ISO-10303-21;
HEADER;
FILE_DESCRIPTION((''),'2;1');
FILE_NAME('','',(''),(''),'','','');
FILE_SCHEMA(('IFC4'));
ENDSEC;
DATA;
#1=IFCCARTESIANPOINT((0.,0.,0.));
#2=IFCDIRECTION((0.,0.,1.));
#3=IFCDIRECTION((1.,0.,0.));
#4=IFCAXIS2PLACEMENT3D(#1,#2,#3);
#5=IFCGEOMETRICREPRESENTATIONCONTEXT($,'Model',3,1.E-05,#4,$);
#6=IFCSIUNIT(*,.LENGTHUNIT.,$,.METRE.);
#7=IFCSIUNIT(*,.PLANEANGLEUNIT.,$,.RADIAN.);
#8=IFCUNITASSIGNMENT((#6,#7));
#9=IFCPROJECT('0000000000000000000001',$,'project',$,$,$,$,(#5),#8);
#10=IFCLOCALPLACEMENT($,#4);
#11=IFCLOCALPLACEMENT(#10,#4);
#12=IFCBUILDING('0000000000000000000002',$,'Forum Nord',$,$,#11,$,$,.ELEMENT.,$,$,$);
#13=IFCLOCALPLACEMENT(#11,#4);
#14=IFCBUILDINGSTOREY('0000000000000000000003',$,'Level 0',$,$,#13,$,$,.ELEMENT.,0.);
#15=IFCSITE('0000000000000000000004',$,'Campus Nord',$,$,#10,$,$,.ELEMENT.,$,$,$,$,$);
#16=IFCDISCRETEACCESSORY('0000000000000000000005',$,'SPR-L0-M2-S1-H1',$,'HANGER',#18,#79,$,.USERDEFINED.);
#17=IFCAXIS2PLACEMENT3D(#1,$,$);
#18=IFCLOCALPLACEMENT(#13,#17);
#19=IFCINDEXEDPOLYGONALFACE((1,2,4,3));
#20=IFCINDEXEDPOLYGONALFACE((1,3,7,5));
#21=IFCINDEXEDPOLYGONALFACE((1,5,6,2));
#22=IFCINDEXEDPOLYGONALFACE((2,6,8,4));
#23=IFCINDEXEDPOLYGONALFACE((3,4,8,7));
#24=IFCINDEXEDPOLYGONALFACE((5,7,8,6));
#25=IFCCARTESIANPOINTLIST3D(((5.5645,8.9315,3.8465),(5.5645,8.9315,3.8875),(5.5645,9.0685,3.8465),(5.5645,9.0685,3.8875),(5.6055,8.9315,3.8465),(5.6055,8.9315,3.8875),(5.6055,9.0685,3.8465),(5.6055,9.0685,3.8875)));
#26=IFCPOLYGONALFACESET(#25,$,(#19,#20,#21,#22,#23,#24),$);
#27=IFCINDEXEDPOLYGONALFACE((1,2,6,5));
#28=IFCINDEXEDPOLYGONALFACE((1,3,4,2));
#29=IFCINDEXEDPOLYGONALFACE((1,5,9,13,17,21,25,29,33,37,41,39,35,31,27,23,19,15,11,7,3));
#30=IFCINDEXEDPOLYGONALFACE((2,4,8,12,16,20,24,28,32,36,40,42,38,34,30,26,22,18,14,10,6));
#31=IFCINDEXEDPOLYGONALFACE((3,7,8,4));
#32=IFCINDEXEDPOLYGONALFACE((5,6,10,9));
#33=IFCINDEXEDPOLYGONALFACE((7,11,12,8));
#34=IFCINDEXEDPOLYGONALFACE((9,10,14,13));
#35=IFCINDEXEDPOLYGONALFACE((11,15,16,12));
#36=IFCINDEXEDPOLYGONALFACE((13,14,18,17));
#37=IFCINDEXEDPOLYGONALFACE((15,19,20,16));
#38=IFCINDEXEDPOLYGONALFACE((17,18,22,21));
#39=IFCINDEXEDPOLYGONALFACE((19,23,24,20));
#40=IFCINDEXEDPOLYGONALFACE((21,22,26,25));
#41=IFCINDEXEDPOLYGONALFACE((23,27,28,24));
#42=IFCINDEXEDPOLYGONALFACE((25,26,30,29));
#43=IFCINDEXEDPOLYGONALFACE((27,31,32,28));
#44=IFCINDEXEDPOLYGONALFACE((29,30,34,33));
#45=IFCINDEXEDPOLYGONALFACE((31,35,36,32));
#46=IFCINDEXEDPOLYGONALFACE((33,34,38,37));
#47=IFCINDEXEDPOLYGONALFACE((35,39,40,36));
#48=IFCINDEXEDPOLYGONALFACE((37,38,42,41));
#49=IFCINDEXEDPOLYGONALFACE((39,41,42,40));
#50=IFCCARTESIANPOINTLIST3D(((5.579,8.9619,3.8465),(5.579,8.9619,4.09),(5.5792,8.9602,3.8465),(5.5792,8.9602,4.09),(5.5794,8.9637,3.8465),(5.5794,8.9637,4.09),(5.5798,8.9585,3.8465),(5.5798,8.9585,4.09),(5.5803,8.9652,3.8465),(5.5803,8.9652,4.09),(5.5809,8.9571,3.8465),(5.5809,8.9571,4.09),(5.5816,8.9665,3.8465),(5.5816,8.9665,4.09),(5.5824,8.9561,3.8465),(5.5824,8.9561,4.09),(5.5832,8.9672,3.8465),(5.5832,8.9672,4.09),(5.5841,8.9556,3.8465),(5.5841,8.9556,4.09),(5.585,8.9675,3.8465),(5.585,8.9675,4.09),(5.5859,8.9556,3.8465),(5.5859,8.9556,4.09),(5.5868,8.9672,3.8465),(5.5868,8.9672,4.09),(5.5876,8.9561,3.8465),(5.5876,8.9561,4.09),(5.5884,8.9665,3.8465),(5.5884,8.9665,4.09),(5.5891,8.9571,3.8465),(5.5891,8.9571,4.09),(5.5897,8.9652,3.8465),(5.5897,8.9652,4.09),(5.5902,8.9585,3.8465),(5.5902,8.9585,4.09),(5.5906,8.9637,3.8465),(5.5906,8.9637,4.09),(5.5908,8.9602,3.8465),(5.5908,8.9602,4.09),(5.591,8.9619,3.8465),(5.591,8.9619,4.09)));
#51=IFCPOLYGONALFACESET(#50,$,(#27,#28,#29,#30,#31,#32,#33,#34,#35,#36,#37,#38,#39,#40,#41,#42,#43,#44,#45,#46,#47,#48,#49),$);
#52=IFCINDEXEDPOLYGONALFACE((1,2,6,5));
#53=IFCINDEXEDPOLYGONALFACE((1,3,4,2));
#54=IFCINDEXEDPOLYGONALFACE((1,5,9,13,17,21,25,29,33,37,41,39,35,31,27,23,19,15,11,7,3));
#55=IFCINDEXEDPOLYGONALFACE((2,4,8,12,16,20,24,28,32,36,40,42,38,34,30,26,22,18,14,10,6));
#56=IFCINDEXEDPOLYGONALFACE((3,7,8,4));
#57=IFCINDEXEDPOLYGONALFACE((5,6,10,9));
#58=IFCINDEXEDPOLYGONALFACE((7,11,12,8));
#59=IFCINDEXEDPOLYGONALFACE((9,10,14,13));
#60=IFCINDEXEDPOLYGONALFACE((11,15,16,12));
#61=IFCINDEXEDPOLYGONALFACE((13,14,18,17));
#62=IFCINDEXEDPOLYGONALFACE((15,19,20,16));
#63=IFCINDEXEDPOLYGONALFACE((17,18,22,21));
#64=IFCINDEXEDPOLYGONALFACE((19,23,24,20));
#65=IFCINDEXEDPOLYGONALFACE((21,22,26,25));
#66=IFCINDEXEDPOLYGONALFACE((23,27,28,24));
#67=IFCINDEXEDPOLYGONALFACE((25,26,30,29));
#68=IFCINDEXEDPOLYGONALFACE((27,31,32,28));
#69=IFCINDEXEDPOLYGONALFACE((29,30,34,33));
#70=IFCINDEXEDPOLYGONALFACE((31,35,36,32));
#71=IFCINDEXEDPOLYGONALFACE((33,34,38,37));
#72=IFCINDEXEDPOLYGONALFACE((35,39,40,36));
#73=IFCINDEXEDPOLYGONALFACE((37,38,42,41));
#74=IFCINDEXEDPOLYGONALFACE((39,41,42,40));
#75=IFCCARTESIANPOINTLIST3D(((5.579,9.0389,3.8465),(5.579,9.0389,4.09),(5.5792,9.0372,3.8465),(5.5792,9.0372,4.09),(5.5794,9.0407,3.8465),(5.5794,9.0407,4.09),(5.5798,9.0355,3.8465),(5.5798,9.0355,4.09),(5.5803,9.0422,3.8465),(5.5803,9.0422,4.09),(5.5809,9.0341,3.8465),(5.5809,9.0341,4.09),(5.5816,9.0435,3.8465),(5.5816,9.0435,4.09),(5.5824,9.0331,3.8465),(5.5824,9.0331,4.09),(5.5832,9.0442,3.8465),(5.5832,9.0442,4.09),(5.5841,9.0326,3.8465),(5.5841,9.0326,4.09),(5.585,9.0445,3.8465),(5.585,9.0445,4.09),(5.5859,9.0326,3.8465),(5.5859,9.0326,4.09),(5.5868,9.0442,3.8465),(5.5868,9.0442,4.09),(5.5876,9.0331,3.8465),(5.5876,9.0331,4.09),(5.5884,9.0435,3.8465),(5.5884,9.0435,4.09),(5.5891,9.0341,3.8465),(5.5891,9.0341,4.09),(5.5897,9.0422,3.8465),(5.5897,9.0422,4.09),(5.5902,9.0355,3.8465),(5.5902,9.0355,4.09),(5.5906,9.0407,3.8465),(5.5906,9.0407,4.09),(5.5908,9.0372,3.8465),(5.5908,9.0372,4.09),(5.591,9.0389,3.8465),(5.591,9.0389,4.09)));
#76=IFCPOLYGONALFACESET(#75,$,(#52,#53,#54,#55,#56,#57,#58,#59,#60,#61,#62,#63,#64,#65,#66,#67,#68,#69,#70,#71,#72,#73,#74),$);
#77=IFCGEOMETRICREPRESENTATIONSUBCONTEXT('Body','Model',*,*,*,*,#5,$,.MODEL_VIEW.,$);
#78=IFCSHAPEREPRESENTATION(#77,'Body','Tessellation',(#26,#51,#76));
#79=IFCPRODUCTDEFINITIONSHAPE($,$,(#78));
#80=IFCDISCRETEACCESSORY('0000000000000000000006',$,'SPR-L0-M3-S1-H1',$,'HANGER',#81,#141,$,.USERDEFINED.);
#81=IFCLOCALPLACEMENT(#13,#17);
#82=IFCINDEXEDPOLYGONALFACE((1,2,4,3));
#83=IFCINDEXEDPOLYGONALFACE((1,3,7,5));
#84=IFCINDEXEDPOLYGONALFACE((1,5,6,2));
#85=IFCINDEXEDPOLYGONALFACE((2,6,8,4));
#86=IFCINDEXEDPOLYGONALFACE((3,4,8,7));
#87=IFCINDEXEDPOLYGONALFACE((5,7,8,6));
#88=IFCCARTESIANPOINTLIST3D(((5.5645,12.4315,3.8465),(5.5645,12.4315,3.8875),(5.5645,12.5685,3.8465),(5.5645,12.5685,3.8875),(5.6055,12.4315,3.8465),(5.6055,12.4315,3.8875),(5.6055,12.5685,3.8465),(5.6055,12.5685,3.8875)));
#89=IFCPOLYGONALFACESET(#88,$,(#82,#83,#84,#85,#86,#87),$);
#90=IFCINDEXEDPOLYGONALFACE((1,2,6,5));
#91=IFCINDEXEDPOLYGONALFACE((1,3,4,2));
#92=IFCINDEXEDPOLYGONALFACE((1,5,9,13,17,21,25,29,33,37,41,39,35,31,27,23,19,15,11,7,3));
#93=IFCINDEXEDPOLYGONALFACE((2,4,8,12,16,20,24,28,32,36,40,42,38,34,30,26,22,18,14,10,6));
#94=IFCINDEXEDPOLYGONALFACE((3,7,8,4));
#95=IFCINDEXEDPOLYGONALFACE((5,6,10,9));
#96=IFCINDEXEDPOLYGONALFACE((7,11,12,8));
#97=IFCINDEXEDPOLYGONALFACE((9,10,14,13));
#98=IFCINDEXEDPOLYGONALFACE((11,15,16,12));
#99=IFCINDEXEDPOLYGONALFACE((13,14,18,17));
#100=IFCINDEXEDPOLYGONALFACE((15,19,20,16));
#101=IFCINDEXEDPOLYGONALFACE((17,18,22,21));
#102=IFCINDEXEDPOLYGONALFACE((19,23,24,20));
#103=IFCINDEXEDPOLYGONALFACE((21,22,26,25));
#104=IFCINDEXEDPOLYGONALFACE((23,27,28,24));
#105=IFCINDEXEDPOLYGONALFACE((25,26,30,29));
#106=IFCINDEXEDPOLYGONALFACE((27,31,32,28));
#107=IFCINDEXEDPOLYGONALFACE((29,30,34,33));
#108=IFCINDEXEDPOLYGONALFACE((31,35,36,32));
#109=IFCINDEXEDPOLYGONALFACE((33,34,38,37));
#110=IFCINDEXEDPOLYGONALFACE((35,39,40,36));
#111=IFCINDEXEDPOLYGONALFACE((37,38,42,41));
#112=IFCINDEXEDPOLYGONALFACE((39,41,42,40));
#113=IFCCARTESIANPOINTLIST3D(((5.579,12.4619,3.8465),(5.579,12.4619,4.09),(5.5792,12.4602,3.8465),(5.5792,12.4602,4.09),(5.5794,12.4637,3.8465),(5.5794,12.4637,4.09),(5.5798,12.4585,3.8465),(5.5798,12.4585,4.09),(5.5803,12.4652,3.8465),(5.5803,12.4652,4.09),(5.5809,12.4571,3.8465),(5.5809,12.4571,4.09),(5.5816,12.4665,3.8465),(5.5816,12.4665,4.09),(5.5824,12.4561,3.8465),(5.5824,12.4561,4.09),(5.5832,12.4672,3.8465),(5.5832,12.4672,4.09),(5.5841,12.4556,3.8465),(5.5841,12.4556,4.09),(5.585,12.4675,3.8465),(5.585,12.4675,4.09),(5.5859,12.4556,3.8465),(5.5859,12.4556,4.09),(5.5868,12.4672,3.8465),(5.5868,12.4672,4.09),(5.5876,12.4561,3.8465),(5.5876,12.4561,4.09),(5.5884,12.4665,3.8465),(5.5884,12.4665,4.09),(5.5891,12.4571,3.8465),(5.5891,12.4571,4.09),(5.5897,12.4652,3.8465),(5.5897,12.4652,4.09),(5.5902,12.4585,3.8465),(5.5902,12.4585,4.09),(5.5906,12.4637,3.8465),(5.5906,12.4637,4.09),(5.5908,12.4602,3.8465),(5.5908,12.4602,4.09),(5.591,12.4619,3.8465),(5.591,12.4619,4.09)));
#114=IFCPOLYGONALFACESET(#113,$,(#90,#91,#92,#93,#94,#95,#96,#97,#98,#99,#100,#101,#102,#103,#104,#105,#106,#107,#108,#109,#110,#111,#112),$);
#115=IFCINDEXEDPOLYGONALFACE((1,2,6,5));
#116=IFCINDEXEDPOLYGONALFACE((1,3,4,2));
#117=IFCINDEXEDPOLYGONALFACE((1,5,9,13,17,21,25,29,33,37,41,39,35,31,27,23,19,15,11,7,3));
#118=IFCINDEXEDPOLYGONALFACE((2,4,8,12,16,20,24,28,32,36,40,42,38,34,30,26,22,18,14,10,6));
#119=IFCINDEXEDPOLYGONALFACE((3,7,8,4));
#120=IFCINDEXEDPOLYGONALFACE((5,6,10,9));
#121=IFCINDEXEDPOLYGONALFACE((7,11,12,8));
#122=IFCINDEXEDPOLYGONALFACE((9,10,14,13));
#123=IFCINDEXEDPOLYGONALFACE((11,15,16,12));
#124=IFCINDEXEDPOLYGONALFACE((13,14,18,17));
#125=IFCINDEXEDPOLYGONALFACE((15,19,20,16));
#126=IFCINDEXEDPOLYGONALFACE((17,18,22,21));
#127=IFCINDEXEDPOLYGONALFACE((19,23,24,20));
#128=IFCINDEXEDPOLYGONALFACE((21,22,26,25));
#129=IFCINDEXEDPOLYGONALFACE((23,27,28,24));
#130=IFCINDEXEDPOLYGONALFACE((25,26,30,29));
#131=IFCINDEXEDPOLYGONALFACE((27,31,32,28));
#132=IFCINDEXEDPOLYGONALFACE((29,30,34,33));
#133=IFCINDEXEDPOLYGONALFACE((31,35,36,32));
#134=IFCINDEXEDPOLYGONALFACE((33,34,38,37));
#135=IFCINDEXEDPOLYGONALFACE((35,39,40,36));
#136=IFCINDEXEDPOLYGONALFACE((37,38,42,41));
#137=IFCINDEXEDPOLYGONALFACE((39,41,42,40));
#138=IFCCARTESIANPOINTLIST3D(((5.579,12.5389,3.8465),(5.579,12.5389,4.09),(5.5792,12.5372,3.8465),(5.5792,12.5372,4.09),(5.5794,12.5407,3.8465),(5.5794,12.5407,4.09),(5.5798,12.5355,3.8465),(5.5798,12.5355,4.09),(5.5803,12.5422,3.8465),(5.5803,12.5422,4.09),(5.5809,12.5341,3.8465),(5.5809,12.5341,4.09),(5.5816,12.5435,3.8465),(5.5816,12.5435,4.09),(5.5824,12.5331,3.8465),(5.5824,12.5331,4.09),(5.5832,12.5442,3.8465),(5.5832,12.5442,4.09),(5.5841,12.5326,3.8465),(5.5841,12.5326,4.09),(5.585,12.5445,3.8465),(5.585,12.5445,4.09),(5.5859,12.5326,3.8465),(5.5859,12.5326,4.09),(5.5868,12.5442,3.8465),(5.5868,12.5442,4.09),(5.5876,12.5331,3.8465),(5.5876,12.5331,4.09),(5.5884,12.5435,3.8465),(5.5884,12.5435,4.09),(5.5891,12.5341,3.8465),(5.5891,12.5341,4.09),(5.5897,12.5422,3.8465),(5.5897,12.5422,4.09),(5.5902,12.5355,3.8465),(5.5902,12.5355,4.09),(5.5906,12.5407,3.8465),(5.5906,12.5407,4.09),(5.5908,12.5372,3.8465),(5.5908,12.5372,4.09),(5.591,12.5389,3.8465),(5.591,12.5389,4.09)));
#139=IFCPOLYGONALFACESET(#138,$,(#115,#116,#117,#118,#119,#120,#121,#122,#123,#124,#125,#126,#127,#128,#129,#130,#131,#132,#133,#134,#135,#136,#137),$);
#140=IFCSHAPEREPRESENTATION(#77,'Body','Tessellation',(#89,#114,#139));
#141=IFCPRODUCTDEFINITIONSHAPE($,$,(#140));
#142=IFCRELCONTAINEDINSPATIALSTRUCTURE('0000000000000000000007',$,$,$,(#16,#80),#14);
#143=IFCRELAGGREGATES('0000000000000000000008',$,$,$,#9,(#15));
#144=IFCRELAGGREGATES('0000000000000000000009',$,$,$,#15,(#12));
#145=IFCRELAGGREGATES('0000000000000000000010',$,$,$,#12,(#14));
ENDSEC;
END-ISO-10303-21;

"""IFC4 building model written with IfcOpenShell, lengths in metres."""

from ifc_helpers import new_model, si_unit, frame, frame_2d, origin_with_axes, origin_2d_with_axis, place, context, subcontext, project, spatial, rectangle, circle, extrude, element, save


model = new_model("IFC4")

# Units and contexts
model_context = context("Model", 3, precision=1e-05, world=origin_with_axes())
body_context = subcontext(model_context, "Body", "Model", "MODEL_VIEW")
ifc_project = project(units=[si_unit("LENGTHUNIT", "METRE"), si_unit("PLANEANGLEUNIT", "RADIAN")], contexts=[model_context])

# Site, building, storey
site_placement = place(None, origin_with_axes())
site = spatial("IfcSite", under=ifc_project, at=site_placement, Name="Campus Nord", CompositionType="ELEMENT")
building_placement = place(site_placement, origin_with_axes())
building = spatial("IfcBuilding", under=site, at=building_placement, Name="Forum Nord", CompositionType="ELEMENT")
storey_placement = place(building_placement, origin_with_axes())
storey = spatial("IfcBuildingStorey", under=building, at=storey_placement, Name="Level 0", CompositionType="ELEMENT", Elevation=0.0)

# Discrete accessories
for number, where, z_axis, x_axis, name in (
    (1, (5.585, 9.0, 3.8875), (0.0, 0.0, 1.0), (0.0, 1.0, 0.0), "SPR-L0-M2-S1-H1"),
    (2, (5.585, 12.5, 3.8875), (0.0, 0.0, 1.0), (0.0, 1.0, 0.0), "SPR-L0-M3-S1-H1"),
):
    element("IfcDiscreteAccessory", number, at=place(storey_placement, frame(where, z_axis=z_axis, x_axis=x_axis)), inside=storey, Name=name, ObjectType="HANGER", PredefinedType="USERDEFINED", context=body_context, shape_type="SweptSolid", body=[
        extrude(rectangle(XDim=0.137, YDim=0.041, at=origin_2d_with_axis()), frame((0.0, 0.0, -0.041), z_axis=(0.0, 0.0, 1.0), x_axis=(1.0, 0.0, 0.0)), (0.0, 0.0, 1.0), 0.041),
        extrude(circle(Radius=0.006, at=frame_2d((-0.0385, 0.0), x_axis=(1.0, 0.0))), frame((0.0, 0.0, -0.041), z_axis=(0.0, 0.0, 1.0), x_axis=(1.0, 0.0, 0.0)), (0.0, 0.0, 1.0), 0.2435),
        extrude(circle(Radius=0.006, at=frame_2d((0.0385, 0.0), x_axis=(1.0, 0.0))), frame((0.0, 0.0, -0.041), z_axis=(0.0, 0.0, 1.0), x_axis=(1.0, 0.0, 0.0)), (0.0, 0.0, 1.0), 0.2435),
    ])

save(model, "model.ifc")
